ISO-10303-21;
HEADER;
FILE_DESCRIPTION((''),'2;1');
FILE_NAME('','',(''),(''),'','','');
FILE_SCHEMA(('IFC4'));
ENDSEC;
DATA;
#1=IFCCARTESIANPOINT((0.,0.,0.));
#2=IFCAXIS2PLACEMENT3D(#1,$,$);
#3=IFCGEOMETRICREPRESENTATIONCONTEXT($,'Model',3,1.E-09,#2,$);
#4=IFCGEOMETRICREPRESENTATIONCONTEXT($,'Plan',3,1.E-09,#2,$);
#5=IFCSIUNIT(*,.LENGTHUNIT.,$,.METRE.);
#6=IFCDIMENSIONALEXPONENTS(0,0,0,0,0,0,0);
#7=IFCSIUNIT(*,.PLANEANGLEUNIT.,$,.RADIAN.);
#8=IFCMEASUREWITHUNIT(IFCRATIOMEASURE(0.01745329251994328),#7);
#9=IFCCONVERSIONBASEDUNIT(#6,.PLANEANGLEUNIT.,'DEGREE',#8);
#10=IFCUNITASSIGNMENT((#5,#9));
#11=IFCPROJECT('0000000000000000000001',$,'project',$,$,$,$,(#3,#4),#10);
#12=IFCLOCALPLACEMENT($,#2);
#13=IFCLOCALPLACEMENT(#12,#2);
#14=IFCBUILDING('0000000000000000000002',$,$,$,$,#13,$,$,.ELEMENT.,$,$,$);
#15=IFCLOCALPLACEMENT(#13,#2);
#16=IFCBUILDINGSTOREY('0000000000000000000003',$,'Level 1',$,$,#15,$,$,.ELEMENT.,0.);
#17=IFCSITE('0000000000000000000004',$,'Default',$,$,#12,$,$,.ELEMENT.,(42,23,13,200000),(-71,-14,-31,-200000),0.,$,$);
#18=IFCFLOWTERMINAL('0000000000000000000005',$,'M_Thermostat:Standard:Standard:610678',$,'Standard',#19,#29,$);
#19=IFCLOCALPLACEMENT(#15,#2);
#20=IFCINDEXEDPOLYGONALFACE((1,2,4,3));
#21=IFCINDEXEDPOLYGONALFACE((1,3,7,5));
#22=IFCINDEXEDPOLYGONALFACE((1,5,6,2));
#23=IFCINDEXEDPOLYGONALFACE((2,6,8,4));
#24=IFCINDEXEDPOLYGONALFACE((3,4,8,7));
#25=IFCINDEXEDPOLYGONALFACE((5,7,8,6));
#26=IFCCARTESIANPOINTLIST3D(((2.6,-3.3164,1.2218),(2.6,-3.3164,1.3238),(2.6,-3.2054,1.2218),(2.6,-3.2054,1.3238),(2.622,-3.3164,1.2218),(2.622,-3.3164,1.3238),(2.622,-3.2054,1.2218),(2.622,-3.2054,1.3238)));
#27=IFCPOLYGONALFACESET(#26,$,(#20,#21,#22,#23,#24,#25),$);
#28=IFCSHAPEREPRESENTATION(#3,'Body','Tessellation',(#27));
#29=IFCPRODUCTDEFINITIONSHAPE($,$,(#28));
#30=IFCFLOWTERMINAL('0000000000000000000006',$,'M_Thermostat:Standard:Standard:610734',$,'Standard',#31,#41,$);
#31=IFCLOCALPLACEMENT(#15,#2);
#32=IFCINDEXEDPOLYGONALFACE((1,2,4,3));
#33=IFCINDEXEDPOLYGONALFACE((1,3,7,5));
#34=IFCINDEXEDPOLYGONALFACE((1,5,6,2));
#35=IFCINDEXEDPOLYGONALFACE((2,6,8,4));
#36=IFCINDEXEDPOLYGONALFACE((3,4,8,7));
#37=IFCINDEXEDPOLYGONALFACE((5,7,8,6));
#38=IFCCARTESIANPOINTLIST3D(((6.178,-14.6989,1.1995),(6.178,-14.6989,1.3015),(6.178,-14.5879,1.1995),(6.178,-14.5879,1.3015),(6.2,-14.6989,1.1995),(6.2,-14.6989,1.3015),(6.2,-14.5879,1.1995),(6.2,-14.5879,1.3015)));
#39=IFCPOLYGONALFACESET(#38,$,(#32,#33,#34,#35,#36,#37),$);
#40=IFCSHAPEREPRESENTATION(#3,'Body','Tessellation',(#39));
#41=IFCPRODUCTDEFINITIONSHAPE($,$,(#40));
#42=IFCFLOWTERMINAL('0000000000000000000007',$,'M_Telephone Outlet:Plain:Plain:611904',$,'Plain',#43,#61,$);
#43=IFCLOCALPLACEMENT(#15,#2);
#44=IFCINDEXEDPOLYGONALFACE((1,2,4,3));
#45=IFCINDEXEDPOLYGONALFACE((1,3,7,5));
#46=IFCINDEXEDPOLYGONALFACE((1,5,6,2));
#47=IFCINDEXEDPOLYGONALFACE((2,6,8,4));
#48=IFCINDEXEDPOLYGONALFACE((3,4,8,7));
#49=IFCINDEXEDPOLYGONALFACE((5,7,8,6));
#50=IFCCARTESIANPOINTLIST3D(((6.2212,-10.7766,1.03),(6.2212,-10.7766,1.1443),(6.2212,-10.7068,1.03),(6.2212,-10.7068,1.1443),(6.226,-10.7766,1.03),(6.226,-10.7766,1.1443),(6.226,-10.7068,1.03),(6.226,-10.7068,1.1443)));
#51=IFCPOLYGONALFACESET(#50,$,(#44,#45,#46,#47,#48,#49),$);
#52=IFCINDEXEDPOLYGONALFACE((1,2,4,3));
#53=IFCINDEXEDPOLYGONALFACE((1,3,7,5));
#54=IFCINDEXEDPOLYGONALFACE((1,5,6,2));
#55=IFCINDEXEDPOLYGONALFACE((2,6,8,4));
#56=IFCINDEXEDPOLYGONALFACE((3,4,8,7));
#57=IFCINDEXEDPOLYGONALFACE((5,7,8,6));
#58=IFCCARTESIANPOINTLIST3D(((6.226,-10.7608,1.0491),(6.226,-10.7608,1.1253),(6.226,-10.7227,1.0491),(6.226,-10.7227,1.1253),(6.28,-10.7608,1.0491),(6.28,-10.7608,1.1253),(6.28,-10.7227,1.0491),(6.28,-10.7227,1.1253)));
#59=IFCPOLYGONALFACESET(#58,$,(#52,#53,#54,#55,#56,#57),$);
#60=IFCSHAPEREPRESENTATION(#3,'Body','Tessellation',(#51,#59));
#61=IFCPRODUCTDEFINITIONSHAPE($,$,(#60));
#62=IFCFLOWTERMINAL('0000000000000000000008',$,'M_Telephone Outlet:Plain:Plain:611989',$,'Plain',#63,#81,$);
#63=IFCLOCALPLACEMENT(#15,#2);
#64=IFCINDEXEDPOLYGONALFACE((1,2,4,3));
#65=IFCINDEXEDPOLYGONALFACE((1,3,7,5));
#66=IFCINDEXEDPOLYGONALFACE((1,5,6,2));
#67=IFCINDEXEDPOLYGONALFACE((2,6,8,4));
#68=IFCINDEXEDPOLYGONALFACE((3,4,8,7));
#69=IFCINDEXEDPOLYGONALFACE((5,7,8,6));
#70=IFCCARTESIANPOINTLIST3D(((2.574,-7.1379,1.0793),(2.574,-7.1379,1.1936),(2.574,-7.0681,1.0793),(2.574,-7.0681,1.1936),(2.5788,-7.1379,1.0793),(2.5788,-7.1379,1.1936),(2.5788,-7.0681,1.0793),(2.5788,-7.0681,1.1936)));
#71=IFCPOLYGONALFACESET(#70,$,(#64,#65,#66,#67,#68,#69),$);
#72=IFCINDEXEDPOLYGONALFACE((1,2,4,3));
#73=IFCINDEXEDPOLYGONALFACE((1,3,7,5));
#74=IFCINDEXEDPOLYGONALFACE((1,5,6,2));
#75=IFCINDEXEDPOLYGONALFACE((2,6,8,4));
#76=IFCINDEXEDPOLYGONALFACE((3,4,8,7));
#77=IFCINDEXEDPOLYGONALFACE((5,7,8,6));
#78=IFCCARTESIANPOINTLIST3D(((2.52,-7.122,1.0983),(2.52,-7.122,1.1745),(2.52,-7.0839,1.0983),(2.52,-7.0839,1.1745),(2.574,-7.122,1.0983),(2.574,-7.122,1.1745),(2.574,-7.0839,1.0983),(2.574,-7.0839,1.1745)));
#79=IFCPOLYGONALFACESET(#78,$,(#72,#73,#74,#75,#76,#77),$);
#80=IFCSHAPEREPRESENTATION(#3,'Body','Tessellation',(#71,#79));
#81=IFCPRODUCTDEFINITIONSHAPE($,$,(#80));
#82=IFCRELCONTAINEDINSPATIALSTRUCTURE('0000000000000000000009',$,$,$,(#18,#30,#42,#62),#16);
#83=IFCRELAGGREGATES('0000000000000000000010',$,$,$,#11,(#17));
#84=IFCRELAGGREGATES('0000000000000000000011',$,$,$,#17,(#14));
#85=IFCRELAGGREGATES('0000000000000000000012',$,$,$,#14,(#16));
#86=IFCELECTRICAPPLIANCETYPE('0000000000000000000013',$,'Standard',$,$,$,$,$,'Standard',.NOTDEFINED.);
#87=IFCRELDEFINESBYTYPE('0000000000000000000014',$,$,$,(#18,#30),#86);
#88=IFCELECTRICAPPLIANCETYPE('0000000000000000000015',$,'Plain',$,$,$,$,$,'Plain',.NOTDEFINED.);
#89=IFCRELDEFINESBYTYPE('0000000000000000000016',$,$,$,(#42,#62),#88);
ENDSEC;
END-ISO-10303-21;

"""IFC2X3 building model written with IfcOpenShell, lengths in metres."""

from ifc_helpers import new_model, entity, si_unit, converted_unit, frame, origin, origin_2d_with_axis, place, context, project, spatial, rectangle, extrude, source, transform, mapped, type_object, type_shapes, element, save


model = new_model("IFC2X3")

# Units and contexts
model_context = context("Model", 3, precision=1e-09, world=origin())
plan_context = context("Plan", 3, precision=1e-09, world=origin())
ifc_project = project(units=[si_unit("LENGTHUNIT", "METRE"), converted_unit("PLANEANGLEUNIT", "DEGREE", entity("IfcRatioMeasure", 0.01745329251994328), si_unit("PLANEANGLEUNIT", "RADIAN"), dimensions=[0, 0, 0, 0, 0, 0, 0])], contexts=[model_context, plan_context])

# Site, building, storey
site_placement = place(None, origin())
site = spatial("IfcSite", under=ifc_project, at=site_placement, Name="Default", CompositionType="ELEMENT", RefLatitude=(42, 23, 13, 200000), RefLongitude=(-71, -14, -31, -200000), RefElevation=0.0)
building_placement = place(site_placement, origin())
building = spatial("IfcBuilding", under=site, at=building_placement, CompositionType="ELEMENT")
storey_placement = place(building_placement, origin())
storey = spatial("IfcBuildingStorey", under=building, at=storey_placement, Name="Level 1", CompositionType="ELEMENT", Elevation=0.0)

# Flow terminals
electric_appliance_type_1 = type_object("IfcElectricApplianceType", Name="Standard", ElementType="Standard", PredefinedType="NOTDEFINED")
shared_shape_1 = source(origin(), model_context, "Body", "SweptSolid", [
    extrude(rectangle(XDim=0.102, YDim=0.111, at=origin_2d_with_axis()), frame((0.0, -0.051, 0.0), z_axis=(0.0, 0.0, 1.0), x_axis=(0.0, 1.0, 0.0)), (0.0, 0.0, 1.0), 0.022),
])
type_shapes(electric_appliance_type_1, [shared_shape_1])
for number, where, z_axis, x_axis, name in (
    (1, (2.6, -3.2609, 1.3238), (1.0, 0.0, 0.0), (0.0, 1.0, 0.0), "M_Thermostat:Standard:Standard:610678"),
    (2, (6.2, -14.6434, 1.3015), (-1.0, 0.0, 0.0), (0.0, -1.0, 0.0), "M_Thermostat:Standard:Standard:610734"),
):
    element("IfcFlowTerminal", number, at=place(storey_placement, frame(where, z_axis=z_axis, x_axis=x_axis)), inside=storey, type_object=electric_appliance_type_1, Name=name, ObjectType="Standard", context=model_context, shape_type="MappedRepresentation", body=[
        mapped(shared_shape_1, transform((0.0, 0.0, 0.0), scale=1.0)),
    ])
electric_appliance_type_2 = type_object("IfcElectricApplianceType", Name="Plain", ElementType="Plain", PredefinedType="NOTDEFINED")
shared_shape_2 = source(origin(), model_context, "Body", "SweptSolid", [
    extrude(rectangle(XDim=0.0699, YDim=0.1143, at=origin_2d_with_axis()), frame((0.0, 0.0, 0.0), z_axis=(0.0, 0.0, 1.0), x_axis=(-1.0, 0.0, 0.0)), (0.0, 0.0, 1.0), 0.0048),
    extrude(rectangle(XDim=0.0381, YDim=0.0762, at=origin_2d_with_axis()), frame((0.0, 0.0, -0.054), z_axis=(0.0, 0.0, 1.0), x_axis=(-1.0, 0.0, 0.0)), (0.0, 0.0, 1.0), 0.054),
])
type_shapes(electric_appliance_type_2, [shared_shape_2])
for number, where, z_axis, x_axis, name in (
    (3, (6.226, -10.7417, 1.0872), (-1.0, 0.0, 0.0), (0.0, -1.0, 0.0), "M_Telephone Outlet:Plain:Plain:611904"),
    (4, (2.574, -7.103, 1.1364), (1.0, 0.0, 0.0), (0.0, 1.0, 0.0), "M_Telephone Outlet:Plain:Plain:611989"),
):
    element("IfcFlowTerminal", number, at=place(storey_placement, frame(where, z_axis=z_axis, x_axis=x_axis)), inside=storey, type_object=electric_appliance_type_2, Name=name, ObjectType="Plain", context=model_context, shape_type="MappedRepresentation", body=[
        mapped(shared_shape_2, transform((0.0, 0.0, 0.0), scale=1.0)),
    ])

save(model, "model.ifc")
